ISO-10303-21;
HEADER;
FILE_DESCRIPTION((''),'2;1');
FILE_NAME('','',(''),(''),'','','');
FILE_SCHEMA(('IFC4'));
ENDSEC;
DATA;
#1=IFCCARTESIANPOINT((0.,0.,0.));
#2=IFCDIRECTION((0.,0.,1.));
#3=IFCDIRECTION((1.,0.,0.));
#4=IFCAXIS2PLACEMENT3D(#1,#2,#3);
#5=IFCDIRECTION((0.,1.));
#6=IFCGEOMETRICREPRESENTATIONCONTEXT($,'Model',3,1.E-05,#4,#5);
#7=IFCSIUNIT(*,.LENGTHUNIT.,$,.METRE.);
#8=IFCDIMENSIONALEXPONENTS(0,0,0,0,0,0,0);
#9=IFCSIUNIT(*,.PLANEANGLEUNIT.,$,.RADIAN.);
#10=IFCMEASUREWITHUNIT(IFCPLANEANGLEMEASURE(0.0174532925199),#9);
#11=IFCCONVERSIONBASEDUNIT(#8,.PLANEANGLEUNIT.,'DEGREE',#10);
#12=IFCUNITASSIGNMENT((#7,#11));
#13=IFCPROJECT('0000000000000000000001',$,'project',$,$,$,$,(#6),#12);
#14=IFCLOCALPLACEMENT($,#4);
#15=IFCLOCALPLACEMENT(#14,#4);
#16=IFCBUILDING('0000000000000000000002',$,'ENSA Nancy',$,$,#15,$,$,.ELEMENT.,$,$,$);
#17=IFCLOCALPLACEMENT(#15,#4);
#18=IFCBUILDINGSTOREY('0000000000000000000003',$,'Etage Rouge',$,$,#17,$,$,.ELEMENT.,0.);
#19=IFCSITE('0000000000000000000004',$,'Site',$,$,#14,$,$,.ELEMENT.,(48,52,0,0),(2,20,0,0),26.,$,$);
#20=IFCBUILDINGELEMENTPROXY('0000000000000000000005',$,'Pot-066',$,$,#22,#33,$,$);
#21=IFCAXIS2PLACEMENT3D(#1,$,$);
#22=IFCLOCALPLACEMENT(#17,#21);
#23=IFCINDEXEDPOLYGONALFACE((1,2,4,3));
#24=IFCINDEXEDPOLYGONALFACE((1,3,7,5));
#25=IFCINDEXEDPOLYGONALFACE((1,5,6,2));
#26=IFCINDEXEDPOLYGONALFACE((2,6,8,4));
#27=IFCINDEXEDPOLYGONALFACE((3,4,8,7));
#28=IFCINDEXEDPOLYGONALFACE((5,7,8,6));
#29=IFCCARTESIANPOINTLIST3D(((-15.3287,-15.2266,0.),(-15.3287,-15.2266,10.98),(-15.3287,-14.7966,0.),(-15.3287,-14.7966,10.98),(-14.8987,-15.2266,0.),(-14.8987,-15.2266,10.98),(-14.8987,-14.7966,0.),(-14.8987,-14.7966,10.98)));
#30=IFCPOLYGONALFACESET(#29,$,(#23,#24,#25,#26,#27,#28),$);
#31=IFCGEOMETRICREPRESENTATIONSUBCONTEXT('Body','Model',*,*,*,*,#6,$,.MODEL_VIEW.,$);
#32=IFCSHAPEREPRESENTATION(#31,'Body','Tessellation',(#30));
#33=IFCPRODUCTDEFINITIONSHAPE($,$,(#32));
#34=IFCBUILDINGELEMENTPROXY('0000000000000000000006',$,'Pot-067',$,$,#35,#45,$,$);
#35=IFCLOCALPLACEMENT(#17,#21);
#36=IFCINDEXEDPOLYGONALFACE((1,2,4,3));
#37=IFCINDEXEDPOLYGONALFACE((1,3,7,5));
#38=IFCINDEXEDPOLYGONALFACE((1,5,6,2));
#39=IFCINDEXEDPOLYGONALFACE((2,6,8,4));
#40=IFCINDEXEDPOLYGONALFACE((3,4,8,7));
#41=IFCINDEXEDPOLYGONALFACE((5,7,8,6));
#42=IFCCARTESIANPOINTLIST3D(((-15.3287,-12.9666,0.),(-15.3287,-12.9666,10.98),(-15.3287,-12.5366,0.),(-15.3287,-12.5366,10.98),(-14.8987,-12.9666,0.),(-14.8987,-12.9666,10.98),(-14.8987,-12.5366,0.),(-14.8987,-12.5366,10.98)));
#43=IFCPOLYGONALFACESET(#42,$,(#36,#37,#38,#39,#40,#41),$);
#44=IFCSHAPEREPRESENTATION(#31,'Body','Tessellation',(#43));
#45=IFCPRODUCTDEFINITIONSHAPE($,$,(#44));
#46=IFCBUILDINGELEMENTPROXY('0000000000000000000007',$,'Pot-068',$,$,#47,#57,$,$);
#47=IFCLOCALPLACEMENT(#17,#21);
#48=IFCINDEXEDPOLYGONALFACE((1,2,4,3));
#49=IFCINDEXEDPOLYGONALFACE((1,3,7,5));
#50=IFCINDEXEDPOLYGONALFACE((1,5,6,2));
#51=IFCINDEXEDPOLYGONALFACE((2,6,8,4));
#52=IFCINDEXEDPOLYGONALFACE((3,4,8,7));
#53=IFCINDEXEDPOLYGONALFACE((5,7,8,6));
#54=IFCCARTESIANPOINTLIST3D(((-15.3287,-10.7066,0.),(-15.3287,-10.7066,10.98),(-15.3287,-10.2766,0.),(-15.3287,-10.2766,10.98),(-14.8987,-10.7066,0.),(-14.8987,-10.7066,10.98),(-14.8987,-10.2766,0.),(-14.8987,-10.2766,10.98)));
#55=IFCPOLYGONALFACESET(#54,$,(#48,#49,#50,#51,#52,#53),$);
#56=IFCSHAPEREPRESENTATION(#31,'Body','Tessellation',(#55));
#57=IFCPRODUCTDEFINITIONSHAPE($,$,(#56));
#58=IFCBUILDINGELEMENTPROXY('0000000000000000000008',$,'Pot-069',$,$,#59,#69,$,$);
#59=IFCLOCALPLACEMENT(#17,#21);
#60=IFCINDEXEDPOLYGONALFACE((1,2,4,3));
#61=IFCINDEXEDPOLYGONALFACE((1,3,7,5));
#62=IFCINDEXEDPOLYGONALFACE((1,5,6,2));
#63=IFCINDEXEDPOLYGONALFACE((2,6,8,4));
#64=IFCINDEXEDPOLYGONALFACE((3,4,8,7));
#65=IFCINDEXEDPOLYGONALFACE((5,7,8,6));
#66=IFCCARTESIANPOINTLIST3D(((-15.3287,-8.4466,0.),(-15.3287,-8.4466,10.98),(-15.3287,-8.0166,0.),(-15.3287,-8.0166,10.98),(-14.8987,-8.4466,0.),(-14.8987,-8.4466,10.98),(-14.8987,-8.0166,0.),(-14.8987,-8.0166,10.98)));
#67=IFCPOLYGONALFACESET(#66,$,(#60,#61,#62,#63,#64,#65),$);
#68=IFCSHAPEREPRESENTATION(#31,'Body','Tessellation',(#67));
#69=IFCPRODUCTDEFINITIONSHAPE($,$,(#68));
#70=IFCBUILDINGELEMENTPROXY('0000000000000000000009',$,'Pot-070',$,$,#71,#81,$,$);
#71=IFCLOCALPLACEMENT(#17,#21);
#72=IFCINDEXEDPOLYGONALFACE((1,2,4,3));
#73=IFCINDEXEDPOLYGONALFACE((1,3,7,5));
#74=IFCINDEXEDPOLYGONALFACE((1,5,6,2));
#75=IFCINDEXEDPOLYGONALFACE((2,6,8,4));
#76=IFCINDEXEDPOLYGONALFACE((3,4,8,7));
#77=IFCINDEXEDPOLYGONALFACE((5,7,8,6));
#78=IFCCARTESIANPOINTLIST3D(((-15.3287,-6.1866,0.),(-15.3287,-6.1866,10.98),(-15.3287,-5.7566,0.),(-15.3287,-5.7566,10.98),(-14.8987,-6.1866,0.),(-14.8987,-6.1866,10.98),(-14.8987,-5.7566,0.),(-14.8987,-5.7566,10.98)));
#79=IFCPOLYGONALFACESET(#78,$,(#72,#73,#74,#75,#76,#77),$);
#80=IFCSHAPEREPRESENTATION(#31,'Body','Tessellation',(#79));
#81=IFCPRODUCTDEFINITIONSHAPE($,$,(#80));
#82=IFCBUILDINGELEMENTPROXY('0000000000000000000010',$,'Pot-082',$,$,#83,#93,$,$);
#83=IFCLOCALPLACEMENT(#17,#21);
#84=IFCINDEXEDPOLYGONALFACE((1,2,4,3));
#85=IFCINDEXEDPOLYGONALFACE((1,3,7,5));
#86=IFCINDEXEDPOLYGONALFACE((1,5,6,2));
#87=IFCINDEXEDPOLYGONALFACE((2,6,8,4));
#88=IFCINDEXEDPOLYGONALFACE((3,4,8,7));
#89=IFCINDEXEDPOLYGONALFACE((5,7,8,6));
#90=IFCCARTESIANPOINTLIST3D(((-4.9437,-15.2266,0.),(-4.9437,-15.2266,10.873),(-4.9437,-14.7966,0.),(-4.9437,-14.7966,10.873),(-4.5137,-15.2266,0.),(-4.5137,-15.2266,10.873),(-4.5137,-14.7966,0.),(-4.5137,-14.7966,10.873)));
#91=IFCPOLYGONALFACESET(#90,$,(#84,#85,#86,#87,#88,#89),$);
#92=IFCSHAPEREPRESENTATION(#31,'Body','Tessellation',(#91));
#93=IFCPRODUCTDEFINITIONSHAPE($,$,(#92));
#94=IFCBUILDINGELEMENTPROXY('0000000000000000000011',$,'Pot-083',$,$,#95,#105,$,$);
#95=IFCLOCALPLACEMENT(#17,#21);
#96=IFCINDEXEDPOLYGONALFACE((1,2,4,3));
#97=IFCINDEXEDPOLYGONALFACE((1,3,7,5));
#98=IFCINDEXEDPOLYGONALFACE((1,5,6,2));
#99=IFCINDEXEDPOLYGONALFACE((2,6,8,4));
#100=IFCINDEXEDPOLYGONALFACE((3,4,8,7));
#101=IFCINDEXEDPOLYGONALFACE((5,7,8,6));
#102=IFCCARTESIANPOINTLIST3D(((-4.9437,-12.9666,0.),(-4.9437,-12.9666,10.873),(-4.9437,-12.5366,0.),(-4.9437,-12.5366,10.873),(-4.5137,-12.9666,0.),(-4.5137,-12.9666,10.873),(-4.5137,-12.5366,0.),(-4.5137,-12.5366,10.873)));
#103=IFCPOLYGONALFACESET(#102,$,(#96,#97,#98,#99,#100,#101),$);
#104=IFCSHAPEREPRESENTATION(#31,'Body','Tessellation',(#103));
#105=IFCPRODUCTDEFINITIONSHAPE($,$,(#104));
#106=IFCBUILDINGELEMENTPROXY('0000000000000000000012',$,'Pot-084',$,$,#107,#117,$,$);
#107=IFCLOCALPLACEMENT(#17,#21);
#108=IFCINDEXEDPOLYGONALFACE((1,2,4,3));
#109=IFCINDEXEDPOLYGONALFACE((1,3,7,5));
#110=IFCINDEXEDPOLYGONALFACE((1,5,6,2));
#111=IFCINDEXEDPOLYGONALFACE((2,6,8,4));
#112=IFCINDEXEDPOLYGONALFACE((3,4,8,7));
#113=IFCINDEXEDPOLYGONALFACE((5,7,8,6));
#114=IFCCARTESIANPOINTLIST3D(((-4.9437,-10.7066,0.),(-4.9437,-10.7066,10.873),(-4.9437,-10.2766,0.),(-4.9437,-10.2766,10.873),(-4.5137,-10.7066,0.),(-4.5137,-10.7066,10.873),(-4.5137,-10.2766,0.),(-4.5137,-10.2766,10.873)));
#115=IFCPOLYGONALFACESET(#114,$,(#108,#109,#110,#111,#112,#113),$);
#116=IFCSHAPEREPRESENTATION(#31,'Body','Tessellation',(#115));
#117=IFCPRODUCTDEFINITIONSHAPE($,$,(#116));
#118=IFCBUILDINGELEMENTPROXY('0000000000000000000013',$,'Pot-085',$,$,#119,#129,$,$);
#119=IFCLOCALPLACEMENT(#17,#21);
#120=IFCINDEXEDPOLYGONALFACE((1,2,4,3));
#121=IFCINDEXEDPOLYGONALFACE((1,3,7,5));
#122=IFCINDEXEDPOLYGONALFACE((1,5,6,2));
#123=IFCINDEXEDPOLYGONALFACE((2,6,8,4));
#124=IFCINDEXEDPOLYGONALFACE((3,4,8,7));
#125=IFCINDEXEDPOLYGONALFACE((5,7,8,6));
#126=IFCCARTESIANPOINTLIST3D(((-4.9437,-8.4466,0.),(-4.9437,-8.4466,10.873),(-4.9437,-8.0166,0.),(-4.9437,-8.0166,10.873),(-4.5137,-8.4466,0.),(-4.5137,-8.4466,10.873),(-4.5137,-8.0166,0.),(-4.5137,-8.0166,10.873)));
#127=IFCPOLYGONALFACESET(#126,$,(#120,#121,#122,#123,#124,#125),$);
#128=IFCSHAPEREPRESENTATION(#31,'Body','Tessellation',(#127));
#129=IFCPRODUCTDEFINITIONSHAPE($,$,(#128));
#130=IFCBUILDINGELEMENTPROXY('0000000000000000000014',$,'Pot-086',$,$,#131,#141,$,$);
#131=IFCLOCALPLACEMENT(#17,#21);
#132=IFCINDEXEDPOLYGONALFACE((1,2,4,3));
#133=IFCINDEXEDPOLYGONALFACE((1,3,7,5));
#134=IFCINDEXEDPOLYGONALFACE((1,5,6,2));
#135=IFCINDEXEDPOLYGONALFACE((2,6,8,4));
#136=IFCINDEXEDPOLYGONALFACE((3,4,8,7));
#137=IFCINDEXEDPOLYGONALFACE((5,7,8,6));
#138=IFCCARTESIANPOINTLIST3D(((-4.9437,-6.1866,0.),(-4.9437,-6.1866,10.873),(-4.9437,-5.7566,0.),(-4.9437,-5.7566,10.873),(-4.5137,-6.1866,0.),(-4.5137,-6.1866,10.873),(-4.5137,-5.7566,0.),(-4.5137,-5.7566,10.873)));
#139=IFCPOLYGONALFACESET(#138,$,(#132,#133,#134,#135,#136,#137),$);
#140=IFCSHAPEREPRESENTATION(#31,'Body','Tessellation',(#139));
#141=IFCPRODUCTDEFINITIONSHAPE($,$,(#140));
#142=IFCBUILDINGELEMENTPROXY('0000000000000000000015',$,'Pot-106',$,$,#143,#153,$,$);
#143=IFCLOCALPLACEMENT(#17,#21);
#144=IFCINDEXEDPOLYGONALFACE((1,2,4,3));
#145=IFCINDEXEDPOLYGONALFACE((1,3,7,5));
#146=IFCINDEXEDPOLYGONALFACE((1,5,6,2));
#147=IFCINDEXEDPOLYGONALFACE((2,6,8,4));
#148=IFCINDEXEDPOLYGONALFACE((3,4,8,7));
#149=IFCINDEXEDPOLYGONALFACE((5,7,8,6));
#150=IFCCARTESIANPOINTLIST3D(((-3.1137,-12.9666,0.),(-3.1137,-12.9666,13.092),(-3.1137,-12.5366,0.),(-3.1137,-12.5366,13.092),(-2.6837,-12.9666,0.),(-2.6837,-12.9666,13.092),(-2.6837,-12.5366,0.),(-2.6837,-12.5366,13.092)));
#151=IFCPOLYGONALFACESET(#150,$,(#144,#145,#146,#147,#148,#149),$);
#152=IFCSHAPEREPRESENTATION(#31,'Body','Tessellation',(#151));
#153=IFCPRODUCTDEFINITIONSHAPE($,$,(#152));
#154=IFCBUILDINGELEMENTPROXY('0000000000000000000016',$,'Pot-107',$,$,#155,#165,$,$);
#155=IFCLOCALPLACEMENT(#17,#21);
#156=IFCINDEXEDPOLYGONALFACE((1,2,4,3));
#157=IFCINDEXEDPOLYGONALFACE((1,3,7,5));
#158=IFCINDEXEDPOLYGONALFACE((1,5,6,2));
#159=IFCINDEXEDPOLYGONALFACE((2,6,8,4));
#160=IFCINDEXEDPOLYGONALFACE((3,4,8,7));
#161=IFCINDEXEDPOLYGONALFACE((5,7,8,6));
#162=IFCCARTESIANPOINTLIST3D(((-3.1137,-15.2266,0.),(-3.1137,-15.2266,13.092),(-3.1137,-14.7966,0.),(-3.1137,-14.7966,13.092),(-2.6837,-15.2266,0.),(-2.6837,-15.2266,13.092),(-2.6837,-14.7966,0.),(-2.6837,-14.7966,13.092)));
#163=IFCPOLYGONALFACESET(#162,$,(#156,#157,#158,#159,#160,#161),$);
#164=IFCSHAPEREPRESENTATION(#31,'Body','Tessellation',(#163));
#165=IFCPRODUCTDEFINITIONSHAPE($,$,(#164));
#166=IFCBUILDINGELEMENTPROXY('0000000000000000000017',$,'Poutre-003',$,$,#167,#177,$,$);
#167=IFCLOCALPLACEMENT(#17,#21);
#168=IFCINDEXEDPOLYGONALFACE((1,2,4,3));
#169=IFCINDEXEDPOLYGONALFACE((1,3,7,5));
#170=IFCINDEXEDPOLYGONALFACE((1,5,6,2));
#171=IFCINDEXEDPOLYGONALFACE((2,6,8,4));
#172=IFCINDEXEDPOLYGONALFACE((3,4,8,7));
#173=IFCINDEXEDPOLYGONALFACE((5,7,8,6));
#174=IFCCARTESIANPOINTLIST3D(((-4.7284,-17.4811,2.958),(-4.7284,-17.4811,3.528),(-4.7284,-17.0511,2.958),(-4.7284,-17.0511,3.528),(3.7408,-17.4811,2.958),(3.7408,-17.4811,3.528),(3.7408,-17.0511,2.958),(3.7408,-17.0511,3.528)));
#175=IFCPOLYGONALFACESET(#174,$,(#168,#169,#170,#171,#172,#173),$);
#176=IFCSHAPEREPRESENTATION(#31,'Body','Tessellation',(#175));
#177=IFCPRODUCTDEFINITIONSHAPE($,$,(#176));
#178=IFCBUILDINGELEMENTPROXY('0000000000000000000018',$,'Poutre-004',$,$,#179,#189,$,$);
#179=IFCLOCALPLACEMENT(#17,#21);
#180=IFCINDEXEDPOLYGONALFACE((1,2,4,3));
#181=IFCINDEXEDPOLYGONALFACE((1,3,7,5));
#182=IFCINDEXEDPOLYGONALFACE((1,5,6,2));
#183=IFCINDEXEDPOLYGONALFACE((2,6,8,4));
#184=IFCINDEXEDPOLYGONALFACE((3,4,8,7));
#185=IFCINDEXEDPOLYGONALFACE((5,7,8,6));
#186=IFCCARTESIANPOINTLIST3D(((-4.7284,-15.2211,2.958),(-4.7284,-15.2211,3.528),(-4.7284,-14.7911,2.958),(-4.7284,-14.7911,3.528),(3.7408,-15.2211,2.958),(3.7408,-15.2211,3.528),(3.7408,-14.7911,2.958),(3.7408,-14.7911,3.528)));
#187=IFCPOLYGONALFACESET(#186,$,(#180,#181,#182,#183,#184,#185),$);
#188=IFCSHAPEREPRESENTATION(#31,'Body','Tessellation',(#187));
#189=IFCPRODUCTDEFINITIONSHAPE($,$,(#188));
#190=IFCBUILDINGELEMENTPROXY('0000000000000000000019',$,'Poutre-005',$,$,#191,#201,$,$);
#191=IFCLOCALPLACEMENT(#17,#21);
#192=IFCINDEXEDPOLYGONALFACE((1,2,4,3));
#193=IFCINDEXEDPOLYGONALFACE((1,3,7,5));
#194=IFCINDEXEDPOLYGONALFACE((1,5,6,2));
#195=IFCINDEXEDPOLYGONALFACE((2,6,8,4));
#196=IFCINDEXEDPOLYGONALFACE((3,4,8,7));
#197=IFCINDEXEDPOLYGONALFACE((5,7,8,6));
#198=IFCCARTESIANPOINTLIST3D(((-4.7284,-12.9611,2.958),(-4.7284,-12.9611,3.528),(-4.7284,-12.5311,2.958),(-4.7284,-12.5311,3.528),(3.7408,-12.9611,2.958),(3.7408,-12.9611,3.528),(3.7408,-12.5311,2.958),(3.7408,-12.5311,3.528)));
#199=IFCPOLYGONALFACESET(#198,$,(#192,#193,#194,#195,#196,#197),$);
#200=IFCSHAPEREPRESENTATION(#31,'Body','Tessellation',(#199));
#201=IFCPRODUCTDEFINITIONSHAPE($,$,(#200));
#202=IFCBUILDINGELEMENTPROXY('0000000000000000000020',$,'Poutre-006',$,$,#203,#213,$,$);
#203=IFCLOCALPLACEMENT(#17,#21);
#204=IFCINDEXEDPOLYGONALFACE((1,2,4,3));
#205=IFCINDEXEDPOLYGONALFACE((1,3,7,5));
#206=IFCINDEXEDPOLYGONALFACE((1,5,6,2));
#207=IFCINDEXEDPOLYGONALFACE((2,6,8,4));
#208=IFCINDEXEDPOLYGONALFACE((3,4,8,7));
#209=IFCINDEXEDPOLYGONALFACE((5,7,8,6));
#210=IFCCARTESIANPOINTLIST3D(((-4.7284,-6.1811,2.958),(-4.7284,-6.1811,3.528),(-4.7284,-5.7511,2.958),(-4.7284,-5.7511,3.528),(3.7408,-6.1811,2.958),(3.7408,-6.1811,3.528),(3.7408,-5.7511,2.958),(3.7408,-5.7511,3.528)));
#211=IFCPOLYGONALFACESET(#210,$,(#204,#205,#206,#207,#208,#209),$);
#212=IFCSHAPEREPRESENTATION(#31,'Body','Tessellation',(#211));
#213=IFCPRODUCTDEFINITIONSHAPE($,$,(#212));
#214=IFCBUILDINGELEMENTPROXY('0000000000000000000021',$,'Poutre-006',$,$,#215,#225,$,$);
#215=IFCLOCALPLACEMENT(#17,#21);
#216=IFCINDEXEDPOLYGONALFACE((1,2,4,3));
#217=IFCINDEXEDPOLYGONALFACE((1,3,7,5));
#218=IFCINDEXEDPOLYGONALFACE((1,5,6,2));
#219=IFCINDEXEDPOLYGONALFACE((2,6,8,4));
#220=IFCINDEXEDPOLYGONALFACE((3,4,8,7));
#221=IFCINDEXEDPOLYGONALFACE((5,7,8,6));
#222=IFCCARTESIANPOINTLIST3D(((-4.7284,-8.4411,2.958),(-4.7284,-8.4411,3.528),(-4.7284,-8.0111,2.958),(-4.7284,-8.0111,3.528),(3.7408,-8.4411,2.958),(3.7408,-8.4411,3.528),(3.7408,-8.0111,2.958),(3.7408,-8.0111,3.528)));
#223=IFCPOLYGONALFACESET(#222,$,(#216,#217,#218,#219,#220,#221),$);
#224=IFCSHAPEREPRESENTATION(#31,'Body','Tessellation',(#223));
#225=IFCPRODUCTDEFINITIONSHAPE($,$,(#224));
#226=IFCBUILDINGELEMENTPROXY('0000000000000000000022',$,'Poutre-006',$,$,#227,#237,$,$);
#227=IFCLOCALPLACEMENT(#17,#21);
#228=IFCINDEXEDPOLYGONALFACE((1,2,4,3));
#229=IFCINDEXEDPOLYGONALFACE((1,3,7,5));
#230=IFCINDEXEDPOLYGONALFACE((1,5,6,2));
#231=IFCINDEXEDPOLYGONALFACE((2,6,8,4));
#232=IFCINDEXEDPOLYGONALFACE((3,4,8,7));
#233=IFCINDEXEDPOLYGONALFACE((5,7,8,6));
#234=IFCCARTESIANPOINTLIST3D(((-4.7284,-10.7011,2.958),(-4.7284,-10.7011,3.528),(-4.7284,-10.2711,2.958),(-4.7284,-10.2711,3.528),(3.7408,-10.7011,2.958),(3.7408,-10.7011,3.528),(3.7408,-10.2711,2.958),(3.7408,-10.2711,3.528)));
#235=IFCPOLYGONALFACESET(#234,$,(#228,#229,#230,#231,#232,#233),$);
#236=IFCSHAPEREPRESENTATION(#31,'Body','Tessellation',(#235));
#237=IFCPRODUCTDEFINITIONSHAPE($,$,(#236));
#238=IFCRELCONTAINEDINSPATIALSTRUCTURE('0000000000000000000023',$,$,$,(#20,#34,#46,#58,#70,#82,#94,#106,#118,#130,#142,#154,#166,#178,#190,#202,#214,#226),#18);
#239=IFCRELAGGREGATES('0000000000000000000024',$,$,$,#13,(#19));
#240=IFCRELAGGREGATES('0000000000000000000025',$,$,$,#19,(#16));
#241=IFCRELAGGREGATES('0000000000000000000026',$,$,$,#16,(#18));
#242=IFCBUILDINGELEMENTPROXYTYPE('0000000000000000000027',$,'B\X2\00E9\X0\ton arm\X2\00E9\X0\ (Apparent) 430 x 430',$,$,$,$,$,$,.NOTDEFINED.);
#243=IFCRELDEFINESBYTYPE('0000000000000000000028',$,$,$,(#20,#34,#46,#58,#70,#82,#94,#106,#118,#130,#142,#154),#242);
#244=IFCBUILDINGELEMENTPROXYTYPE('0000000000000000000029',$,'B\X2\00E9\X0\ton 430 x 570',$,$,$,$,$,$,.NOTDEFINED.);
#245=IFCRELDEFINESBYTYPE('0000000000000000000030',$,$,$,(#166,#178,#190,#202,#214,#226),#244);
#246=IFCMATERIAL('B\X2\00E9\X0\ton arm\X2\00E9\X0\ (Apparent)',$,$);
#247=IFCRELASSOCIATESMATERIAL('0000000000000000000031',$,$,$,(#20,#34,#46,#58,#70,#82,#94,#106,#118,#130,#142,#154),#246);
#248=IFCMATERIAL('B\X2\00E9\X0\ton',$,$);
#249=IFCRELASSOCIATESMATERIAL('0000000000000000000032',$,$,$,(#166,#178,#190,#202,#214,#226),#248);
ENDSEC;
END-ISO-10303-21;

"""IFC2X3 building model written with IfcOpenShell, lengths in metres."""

from ifc_helpers import new_model, entity, si_unit, converted_unit, direction, frame, frame_2d, origin_with_axes, origin_2d_with_axis, place, context, subcontext, project, spatial, rectangle, extrude, material, type_object, element, save


model = new_model("IFC2X3")

# Units and contexts
model_context = context("Model", 3, precision=1e-05, world=origin_with_axes(), true_north=direction((0.0, 1.0)))
body_context = subcontext(model_context, "Body", "Model", "MODEL_VIEW")
ifc_project = project(units=[si_unit("LENGTHUNIT", "METRE"), converted_unit("PLANEANGLEUNIT", "DEGREE", entity("IfcPlaneAngleMeasure", 0.0174532925199), si_unit("PLANEANGLEUNIT", "RADIAN"), dimensions=[0, 0, 0, 0, 0, 0, 0])], contexts=[model_context])

# Site, building, storey
site_placement = place(None, origin_with_axes())
site = spatial("IfcSite", under=ifc_project, at=site_placement, Name="Site", CompositionType="ELEMENT", RefLatitude=(48, 52, 0, 0), RefLongitude=(2, 20, 0, 0), RefElevation=26.0)
building_placement = place(site_placement, origin_with_axes())
building = spatial("IfcBuilding", under=site, at=building_placement, Name="ENSA Nancy", CompositionType="ELEMENT")
storey_placement = place(building_placement, origin_with_axes())
storey = spatial("IfcBuildingStorey", under=building, at=storey_placement, Name="Etage Rouge", CompositionType="ELEMENT", Elevation=0.0)

# Building element proxies
ifc_material_1 = material(Name="Béton armé (Apparent)")
building_element_proxy_type_1 = type_object("IfcBuildingElementProxyType", Name="Béton armé (Apparent) 430 x 430", PredefinedType="NOTDEFINED")
for number, where, z_axis, x_axis, name in (
    (1, (-15.1137, -15.0116, 0.0), (0.0, 0.0, 1.0), (1.0, 0.0, 0.0), "Pot-066"),
    (2, (-15.1137, -12.7516, 0.0), (0.0, 0.0, 1.0), (1.0, 0.0, 0.0), "Pot-067"),
    (3, (-15.1137, -10.4916, 0.0), (0.0, 0.0, 1.0), (1.0, 0.0, 0.0), "Pot-068"),
    (4, (-15.1137, -8.2316, 0.0), (0.0, 0.0, 1.0), (1.0, 0.0, 0.0), "Pot-069"),
    (5, (-15.1137, -5.9716, 0.0), (0.0, 0.0, 1.0), (1.0, 0.0, 0.0), "Pot-070"),
):
    element("IfcBuildingElementProxy", number, at=place(storey_placement, frame(where, z_axis=z_axis, x_axis=x_axis)), inside=storey, type_object=building_element_proxy_type_1, material=ifc_material_1, Name=name, context=body_context, shape_type="SweptSolid", body=[
        extrude(rectangle(XDim=0.43, YDim=0.43, at=origin_2d_with_axis()), origin_with_axes(), (0.0, 0.0, 1.0), 10.98),
    ])
for number, where, z_axis, x_axis, name in (
    (6, (-4.7287, -15.0116, 0.0), (0.0, 0.0, 1.0), (1.0, 0.0, 0.0), "Pot-082"),
    (7, (-4.7287, -12.7516, 0.0), (0.0, 0.0, 1.0), (1.0, 0.0, 0.0), "Pot-083"),
    (8, (-4.7287, -10.4916, 0.0), (0.0, 0.0, 1.0), (1.0, 0.0, 0.0), "Pot-084"),
    (9, (-4.7287, -8.2316, 0.0), (0.0, 0.0, 1.0), (1.0, 0.0, 0.0), "Pot-085"),
    (10, (-4.7287, -5.9716, 0.0), (0.0, 0.0, 1.0), (1.0, 0.0, 0.0), "Pot-086"),
):
    element("IfcBuildingElementProxy", number, at=place(storey_placement, frame(where, z_axis=z_axis, x_axis=x_axis)), inside=storey, type_object=building_element_proxy_type_1, material=ifc_material_1, Name=name, context=body_context, shape_type="SweptSolid", body=[
        extrude(rectangle(XDim=0.43, YDim=0.43, at=origin_2d_with_axis()), origin_with_axes(), (0.0, 0.0, 1.0), 10.873),
    ])
for number, where, z_axis, x_axis, name in (
    (11, (-2.8987, -12.7516, 0.0), (0.0, 0.0, 1.0), (1.0, 0.0, 0.0), "Pot-106"),
    (12, (-2.8987, -15.0116, 0.0), (0.0, 0.0, 1.0), (1.0, 0.0, 0.0), "Pot-107"),
):
    element("IfcBuildingElementProxy", number, at=place(storey_placement, frame(where, z_axis=z_axis, x_axis=x_axis)), inside=storey, type_object=building_element_proxy_type_1, material=ifc_material_1, Name=name, context=body_context, shape_type="SweptSolid", body=[
        extrude(rectangle(XDim=0.43, YDim=0.43, at=origin_2d_with_axis()), origin_with_axes(), (0.0, 0.0, 1.0), 13.092),
    ])
ifc_material_2 = material(Name="Béton")
building_element_proxy_type_2 = type_object("IfcBuildingElementProxyType", Name="Béton 430 x 570", PredefinedType="NOTDEFINED")
for number, where, z_axis, x_axis, name in (
    (13, (-4.7284, -17.2661, 3.528), (0.0, 0.0, 1.0), (0.0, -1.0, 0.0), "Poutre-003"),
    (14, (-4.7284, -15.0061, 3.528), (0.0, 0.0, 1.0), (0.0, -1.0, 0.0), "Poutre-004"),
    (15, (-4.7284, -12.7461, 3.528), (0.0, 0.0, 1.0), (0.0, -1.0, 0.0), "Poutre-005"),
    (16, (-4.7284, -5.9661, 3.528), (0.0, 0.0, 1.0), (0.0, -1.0, 0.0), "Poutre-006"),
    (17, (-4.7284, -8.2261, 3.528), (0.0, 0.0, 1.0), (0.0, -1.0, 0.0), "Poutre-006"),
    (18, (-4.7284, -10.4861, 3.528), (0.0, 0.0, 1.0), (0.0, -1.0, 0.0), "Poutre-006"),
):
    element("IfcBuildingElementProxy", number, at=place(storey_placement, frame(where, z_axis=z_axis, x_axis=x_axis)), inside=storey, type_object=building_element_proxy_type_2, material=ifc_material_2, Name=name, context=body_context, shape_type="SweptSolid", body=[
        extrude(rectangle(XDim=0.57, YDim=0.43, at=frame_2d((-0.285, 0.0), x_axis=(1.0, 0.0))), frame((0.0, 0.0, 0.0), z_axis=(0.0, 1.0, 0.0), x_axis=(0.0, 0.0, 1.0)), (0.0, 0.0, 1.0), 8.4691),
    ])

save(model, "model.ifc")
